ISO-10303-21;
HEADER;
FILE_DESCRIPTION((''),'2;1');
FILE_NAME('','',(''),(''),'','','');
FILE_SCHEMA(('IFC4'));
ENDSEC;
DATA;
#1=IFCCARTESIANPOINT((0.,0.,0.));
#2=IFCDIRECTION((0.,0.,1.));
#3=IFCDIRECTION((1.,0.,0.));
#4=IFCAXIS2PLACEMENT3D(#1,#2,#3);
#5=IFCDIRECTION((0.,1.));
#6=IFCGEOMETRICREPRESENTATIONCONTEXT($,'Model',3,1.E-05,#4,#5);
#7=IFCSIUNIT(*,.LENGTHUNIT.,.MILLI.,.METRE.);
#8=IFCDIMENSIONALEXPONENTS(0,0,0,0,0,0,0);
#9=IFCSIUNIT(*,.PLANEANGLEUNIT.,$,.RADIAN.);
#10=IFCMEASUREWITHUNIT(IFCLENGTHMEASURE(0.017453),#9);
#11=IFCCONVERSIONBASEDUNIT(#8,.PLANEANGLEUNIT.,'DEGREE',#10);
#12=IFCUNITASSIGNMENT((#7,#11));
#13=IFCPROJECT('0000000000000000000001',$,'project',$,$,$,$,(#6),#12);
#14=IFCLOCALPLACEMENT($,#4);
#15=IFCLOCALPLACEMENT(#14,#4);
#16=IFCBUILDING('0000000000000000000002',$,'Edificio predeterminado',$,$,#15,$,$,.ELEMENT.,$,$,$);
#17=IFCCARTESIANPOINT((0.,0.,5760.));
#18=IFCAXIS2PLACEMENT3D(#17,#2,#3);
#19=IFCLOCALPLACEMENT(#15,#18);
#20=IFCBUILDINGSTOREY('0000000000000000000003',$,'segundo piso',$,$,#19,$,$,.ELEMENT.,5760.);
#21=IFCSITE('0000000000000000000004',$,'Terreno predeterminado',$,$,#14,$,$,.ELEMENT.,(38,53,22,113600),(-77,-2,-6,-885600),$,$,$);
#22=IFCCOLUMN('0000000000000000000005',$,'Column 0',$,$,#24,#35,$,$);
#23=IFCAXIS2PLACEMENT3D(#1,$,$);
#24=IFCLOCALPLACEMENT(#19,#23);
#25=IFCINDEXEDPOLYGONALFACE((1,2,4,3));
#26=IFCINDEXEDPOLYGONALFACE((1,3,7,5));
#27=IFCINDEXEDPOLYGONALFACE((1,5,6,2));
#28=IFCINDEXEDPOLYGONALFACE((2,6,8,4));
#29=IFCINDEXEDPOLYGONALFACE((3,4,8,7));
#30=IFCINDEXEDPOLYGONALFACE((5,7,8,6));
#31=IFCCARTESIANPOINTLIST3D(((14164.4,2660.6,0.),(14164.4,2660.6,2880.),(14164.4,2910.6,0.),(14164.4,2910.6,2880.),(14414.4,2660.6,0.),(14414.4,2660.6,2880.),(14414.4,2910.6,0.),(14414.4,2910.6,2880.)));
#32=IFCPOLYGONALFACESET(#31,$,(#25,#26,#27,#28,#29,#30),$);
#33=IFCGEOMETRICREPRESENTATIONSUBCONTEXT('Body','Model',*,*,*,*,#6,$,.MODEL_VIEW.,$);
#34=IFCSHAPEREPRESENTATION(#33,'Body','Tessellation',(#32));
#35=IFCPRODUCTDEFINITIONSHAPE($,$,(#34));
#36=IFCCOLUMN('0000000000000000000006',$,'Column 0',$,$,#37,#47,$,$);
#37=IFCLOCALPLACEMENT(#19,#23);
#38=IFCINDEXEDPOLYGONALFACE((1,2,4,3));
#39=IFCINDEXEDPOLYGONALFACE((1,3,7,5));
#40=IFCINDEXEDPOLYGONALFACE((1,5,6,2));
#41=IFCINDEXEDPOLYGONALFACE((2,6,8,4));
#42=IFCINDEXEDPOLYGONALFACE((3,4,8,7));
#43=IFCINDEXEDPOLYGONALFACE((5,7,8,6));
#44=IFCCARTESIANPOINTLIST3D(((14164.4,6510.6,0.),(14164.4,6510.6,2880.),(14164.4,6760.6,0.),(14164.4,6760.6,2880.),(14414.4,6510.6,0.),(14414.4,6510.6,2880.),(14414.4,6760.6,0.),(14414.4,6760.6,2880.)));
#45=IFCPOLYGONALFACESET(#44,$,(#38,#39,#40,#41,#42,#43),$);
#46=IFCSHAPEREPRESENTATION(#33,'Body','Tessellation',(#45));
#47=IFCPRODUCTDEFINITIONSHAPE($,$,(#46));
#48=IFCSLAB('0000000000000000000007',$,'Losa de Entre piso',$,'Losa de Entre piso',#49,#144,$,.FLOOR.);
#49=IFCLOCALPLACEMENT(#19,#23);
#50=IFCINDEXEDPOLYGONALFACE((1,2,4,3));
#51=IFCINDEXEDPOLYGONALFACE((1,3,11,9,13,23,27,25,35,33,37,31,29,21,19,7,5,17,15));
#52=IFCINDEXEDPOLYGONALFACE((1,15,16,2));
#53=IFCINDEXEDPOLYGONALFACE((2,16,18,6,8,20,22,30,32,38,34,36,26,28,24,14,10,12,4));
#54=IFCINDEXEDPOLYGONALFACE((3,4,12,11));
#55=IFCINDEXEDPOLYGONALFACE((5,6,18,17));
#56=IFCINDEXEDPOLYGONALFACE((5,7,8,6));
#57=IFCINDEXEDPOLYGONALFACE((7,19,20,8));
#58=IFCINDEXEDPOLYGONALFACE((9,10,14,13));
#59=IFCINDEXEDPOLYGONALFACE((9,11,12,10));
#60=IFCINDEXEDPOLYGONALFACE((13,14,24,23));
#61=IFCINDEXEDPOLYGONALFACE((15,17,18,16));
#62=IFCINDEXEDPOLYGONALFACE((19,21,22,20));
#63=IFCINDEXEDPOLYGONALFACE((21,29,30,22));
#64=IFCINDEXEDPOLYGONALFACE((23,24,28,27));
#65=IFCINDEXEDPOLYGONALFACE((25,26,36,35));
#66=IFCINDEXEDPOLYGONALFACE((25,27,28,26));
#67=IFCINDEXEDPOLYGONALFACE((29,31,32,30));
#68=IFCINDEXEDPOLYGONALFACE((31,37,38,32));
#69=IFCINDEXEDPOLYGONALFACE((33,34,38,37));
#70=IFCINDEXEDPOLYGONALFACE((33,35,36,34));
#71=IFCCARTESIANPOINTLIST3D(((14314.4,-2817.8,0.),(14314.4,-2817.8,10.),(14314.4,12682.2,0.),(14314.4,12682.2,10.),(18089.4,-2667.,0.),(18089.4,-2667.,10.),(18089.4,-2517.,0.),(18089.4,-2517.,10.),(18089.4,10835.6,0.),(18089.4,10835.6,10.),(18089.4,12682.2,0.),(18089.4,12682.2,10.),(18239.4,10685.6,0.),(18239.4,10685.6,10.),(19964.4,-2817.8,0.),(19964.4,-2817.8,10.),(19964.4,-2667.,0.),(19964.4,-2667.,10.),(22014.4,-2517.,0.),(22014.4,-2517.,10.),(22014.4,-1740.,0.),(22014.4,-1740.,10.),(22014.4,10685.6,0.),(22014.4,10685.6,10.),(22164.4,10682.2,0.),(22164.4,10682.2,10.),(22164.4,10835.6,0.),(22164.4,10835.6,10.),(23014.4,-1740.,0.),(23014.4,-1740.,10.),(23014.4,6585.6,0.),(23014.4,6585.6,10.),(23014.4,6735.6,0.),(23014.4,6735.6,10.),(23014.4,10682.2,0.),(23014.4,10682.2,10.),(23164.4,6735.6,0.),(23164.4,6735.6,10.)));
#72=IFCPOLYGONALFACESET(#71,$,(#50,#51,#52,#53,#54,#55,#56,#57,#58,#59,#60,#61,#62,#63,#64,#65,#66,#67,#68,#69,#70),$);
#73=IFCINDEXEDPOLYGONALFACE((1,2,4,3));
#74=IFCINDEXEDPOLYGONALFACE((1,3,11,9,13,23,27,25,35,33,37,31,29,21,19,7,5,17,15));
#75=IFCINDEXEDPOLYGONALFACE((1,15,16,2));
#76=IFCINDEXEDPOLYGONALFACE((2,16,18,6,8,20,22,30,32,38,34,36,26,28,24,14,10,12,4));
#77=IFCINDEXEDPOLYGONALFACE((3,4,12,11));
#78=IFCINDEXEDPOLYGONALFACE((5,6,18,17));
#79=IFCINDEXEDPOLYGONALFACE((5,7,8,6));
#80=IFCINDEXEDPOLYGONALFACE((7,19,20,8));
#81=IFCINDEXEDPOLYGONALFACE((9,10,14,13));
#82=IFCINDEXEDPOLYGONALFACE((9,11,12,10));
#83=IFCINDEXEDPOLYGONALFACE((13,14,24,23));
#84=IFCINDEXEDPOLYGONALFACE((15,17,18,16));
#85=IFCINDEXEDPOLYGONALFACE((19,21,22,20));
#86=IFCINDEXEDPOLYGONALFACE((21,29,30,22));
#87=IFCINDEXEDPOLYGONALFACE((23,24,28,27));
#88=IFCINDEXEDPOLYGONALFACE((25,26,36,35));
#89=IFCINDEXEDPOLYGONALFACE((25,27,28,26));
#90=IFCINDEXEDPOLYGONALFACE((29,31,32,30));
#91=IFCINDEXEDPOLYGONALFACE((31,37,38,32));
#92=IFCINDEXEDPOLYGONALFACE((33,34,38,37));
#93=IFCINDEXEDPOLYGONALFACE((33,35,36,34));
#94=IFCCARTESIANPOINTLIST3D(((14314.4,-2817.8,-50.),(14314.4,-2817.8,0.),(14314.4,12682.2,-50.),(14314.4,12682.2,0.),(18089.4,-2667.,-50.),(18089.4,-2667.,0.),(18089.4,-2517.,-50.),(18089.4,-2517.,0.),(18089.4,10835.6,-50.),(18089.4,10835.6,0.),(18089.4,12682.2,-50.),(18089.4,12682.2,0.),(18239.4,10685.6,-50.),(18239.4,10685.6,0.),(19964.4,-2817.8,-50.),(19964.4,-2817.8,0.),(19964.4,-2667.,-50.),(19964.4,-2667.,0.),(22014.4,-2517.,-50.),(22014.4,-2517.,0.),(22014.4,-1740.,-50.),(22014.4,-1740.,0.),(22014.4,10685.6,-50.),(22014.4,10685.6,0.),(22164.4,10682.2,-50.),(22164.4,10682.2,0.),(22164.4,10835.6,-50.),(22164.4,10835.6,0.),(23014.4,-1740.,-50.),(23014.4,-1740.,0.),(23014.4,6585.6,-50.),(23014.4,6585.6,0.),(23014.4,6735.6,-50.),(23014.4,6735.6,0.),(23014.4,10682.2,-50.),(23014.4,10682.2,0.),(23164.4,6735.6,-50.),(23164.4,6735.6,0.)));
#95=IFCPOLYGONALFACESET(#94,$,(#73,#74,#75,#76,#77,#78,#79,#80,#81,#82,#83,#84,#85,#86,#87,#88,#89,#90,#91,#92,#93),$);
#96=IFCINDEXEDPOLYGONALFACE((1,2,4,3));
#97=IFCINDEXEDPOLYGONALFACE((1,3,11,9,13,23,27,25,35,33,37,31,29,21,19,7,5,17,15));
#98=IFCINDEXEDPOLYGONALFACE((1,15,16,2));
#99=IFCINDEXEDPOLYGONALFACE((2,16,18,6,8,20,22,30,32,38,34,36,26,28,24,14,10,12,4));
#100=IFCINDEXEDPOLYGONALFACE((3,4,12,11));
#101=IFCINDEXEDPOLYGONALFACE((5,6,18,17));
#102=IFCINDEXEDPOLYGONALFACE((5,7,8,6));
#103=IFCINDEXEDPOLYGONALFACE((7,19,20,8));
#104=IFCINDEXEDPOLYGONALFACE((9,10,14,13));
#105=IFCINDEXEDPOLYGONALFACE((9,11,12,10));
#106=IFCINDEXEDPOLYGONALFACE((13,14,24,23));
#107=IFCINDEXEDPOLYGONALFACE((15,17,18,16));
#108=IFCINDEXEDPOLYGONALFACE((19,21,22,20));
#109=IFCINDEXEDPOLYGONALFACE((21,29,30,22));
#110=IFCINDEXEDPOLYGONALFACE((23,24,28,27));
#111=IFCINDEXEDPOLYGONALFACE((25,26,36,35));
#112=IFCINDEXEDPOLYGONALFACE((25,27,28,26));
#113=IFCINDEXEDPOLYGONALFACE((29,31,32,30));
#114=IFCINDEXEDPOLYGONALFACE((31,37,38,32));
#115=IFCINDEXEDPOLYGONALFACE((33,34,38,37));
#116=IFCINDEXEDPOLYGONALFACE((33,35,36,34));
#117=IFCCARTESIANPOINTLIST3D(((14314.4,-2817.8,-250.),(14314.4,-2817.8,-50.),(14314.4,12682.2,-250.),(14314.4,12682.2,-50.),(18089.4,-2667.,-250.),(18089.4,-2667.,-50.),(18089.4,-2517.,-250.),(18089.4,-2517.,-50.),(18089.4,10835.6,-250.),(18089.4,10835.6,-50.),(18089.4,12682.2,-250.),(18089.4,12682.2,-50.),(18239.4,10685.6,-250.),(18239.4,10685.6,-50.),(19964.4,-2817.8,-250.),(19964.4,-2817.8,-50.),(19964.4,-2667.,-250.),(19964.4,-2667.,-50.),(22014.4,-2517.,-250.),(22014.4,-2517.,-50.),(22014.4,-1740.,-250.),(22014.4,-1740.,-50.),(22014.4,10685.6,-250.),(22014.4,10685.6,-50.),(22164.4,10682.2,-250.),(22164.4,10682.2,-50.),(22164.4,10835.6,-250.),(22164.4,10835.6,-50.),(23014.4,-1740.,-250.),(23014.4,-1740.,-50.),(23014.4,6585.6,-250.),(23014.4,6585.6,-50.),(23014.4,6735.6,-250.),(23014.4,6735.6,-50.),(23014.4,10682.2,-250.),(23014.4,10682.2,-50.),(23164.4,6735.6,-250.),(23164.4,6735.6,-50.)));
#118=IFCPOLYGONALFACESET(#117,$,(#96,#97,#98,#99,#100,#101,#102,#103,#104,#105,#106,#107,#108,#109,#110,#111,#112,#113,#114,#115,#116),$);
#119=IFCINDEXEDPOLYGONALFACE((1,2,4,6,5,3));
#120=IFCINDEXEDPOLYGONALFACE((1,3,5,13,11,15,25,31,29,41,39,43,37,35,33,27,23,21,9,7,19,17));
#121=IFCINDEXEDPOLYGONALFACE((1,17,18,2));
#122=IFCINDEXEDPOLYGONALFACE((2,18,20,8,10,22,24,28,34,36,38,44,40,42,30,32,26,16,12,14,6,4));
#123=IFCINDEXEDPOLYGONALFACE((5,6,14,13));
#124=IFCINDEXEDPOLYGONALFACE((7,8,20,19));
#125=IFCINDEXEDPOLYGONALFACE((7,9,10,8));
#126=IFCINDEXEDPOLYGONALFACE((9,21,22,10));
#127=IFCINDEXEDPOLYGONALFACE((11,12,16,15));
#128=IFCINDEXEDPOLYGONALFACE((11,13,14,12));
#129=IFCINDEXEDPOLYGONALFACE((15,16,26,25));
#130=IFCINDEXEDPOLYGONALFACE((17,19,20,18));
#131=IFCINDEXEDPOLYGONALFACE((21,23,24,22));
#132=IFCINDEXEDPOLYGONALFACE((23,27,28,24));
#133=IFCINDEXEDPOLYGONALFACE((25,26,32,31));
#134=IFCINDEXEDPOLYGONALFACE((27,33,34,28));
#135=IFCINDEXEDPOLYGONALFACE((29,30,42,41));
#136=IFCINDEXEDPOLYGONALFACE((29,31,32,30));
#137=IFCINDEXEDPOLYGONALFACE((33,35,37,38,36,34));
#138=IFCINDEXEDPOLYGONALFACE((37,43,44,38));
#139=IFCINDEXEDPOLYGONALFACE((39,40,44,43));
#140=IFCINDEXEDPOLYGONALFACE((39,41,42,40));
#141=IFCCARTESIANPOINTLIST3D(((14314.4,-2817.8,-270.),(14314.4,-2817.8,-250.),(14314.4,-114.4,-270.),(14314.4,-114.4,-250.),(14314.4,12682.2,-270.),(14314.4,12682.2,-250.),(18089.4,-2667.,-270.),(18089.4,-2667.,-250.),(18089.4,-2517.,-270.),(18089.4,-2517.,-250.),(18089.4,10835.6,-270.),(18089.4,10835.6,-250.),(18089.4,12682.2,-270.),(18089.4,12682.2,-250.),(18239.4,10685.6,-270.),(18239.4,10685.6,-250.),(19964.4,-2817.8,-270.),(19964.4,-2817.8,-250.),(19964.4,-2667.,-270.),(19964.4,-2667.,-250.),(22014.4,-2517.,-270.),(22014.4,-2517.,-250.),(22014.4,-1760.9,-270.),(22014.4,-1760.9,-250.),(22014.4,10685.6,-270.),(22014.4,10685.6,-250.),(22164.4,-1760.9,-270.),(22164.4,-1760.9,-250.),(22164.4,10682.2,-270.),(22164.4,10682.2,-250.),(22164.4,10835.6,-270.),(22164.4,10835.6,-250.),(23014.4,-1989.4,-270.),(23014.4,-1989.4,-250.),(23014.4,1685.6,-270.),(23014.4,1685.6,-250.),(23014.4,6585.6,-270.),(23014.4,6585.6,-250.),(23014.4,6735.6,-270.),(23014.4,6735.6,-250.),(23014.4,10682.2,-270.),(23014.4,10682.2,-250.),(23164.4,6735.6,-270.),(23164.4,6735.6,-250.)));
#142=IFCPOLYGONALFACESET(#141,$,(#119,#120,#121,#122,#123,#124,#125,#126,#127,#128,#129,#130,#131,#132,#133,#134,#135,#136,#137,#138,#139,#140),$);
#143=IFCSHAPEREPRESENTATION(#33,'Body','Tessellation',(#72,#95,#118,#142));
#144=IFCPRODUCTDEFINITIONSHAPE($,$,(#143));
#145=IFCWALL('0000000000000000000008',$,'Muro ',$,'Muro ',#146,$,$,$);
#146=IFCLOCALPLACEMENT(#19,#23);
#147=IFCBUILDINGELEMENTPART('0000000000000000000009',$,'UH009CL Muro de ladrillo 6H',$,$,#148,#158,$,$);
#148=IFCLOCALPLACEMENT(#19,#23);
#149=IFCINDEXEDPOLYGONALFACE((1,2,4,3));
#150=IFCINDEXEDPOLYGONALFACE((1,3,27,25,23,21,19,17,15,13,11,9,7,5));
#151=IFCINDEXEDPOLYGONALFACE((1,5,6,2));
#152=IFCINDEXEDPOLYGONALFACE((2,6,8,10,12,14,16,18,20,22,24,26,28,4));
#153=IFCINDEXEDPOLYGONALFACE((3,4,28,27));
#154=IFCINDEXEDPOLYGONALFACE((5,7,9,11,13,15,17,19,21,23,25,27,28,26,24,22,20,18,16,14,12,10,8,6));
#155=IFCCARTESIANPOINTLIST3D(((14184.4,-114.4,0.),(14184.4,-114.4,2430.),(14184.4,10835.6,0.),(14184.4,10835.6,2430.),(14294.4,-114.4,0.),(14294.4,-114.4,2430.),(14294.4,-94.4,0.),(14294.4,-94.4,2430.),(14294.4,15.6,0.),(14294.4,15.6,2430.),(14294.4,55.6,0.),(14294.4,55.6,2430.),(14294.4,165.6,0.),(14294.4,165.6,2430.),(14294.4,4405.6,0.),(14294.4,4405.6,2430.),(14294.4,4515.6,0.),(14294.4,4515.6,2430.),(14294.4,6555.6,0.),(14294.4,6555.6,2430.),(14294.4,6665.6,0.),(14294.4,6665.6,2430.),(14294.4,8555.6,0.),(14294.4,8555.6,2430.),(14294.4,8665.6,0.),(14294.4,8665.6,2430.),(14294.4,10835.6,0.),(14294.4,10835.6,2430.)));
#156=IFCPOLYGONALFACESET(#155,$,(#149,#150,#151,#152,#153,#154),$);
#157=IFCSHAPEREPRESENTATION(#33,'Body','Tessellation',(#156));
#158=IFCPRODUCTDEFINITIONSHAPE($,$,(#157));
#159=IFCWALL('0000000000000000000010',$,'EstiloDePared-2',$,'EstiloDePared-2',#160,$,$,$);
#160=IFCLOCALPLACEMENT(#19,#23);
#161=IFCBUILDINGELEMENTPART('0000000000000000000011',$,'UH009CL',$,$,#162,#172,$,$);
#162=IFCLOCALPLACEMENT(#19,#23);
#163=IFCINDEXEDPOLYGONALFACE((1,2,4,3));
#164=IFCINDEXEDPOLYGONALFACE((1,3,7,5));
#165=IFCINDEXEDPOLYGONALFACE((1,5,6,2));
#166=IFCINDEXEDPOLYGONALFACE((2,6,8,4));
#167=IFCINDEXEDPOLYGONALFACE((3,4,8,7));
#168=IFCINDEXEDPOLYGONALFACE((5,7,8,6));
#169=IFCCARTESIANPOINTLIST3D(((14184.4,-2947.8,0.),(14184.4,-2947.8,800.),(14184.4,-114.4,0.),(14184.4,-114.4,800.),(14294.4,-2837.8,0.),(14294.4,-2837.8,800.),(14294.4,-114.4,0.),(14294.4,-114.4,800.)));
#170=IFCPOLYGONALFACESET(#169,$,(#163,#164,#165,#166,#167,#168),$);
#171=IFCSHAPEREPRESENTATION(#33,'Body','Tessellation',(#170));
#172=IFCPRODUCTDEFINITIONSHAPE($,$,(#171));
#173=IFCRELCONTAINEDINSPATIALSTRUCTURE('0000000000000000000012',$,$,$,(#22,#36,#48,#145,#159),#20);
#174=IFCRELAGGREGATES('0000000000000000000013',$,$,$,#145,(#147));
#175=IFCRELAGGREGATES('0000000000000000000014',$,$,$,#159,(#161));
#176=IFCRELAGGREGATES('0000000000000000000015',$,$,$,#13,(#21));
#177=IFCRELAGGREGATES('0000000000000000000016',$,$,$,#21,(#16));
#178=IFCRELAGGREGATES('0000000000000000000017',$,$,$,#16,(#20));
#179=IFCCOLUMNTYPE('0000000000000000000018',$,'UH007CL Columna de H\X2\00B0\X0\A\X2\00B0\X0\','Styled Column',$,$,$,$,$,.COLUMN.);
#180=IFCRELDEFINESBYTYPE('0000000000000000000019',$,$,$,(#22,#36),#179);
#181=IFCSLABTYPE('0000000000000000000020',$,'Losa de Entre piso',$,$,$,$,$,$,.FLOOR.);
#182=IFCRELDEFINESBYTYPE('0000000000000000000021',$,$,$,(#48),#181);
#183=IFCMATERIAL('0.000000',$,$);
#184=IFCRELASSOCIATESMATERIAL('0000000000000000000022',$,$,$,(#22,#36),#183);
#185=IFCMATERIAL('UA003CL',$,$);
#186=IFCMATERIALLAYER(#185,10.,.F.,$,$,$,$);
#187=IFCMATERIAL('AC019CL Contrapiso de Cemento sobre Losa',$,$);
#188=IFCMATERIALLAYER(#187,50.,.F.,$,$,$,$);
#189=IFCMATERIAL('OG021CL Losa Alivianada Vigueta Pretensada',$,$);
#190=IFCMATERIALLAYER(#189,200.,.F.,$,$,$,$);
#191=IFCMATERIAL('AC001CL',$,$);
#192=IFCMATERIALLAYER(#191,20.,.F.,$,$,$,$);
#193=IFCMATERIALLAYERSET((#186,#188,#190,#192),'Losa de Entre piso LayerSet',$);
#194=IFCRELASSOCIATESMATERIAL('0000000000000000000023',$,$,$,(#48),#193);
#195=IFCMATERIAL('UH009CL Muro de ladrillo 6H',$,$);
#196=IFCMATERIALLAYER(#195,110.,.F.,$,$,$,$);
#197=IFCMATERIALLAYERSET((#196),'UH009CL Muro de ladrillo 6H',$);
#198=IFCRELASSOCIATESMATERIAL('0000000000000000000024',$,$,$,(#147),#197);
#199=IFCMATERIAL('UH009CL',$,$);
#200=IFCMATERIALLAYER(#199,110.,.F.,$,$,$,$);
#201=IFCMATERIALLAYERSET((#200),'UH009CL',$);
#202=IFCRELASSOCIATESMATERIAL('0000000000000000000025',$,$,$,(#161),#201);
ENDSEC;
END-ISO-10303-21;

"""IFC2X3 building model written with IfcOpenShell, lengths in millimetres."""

from ifc_helpers import new_model, entity, si_unit, converted_unit, direction, frame, origin_with_axes, place, context, subcontext, project, spatial, polyline, outline, extrude, material, layer, layer_set, layer_usage, type_object, element, aggregate, save


model = new_model("IFC2X3")

# Units and contexts
model_context = context("Model", 3, precision=1e-05, world=origin_with_axes(), true_north=direction((0.0, 1.0)))
body_context = subcontext(model_context, "Body", "Model", "MODEL_VIEW")
ifc_project = project(units=[si_unit("LENGTHUNIT", "METRE", prefix="MILLI"), converted_unit("PLANEANGLEUNIT", "DEGREE", entity("IfcLengthMeasure", 0.017453), si_unit("PLANEANGLEUNIT", "RADIAN"), dimensions=[0, 0, 0, 0, 0, 0, 0])], contexts=[model_context])

# Site, building, storey
site_placement = place(None, origin_with_axes())
site = spatial("IfcSite", under=ifc_project, at=site_placement, Name="Terreno predeterminado", CompositionType="ELEMENT", RefLatitude=(38, 53, 22, 113600), RefLongitude=(-77, -2, -6, -885600))
building_placement = place(site_placement, origin_with_axes())
building = spatial("IfcBuilding", under=site, at=building_placement, Name="Edificio predeterminado", CompositionType="ELEMENT")
storey_placement = place(building_placement, frame((0.0, 0.0, 5760.0), z_axis=(0.0, 0.0, 1.0), x_axis=(1.0, 0.0, 0.0)))
storey = spatial("IfcBuildingStorey", under=building, at=storey_placement, Name="segundo piso", CompositionType="ELEMENT", Elevation=5760.0)

# Columns
ifc_material_1 = material(Name="0.000000")
column_type = type_object("IfcColumnType", Name="UH007CL Columna de H°A°", Description="Styled Column", PredefinedType="COLUMN")
for number, where, z_axis, x_axis, name in (
    (1, (14289.4, 2785.6, 0.0), (0.0, 0.0, 1.0), (1.0, 0.0, 0.0), "Column 0"),
    (2, (14289.4, 6635.6, 0.0), (0.0, 0.0, 1.0), (1.0, 0.0, 0.0), "Column 0"),
):
    element("IfcColumn", number, at=place(storey_placement, frame(where, z_axis=z_axis, x_axis=x_axis)), inside=storey, type_object=column_type, material=ifc_material_1, Name=name, context=body_context, shape_type="SweptSolid", body=[
        extrude(outline(polyline([(-125.0, -125.0), (125.0, -125.0), (125.0, 125.0), (-125.0, 125.0), (-125.0, -125.0)])), origin_with_axes(), (0.0, 0.0, 1.0), 2880.0),
    ])

# Slab
ifc_material_2 = material(Name="UA003CL")
ifc_layer_1 = layer(ifc_material_2, 10.0, ventilated=False)
ifc_material_3 = material(Name="AC019CL Contrapiso de Cemento sobre Losa")
ifc_layer_2 = layer(ifc_material_3, 50.0, ventilated=False)
ifc_material_4 = material(Name="OG021CL Losa Alivianada Vigueta Pretensada")
ifc_layer_3 = layer(ifc_material_4, 200.0, ventilated=False)
ifc_material_5 = material(Name="AC001CL")
ifc_layer_4 = layer(ifc_material_5, 20.0, ventilated=False)
ifc_layer_set_1 = layer_set([ifc_layer_1, ifc_layer_2, ifc_layer_3, ifc_layer_4], Name="Losa de Entre piso LayerSet")
ifc_layer_usage_1 = layer_usage(ifc_layer_set_1, "AXIS3", "POSITIVE", 0.0)
slab_type = type_object("IfcSlabType", Name="Losa de Entre piso", PredefinedType="FLOOR")
slab_placement = place(storey_placement, frame((0.0, 0.0, -5760.0), z_axis=(0.0, 0.0, 1.0), x_axis=(1.0, 0.0, 0.0)))
element("IfcSlab", 3, at=slab_placement, inside=storey, type_object=slab_type, material=ifc_layer_usage_1, Name="Losa de Entre piso", ObjectType="Losa de Entre piso", PredefinedType="FLOOR", context=body_context, shape_type="SweptSolid", body=[
    extrude(outline(polyline([(0.0, -777.0), (-1000.0, -777.0), (-1000.0, -9102.6), (-1150.0, -9252.6), (-1000.0, -9252.6), (-1000.0, -13199.1), (-150.0, -13199.1), (-150.0, -13352.6), (0.0, -13202.6), (3775.0, -13202.6), (3925.0, -13352.6), (3925.0, -15199.1), (7700.0, -15199.1), (7700.0, 300.9), (2050.0, 300.9), (2050.0, 150.0), (3925.0, 150.0), (3925.0, 0.0), (0.0, 0.0), (0.0, -777.0)])), frame((22014.4, -2517.0, 5760.0), z_axis=(0.0, 0.0, 1.0), x_axis=(-1.0, 0.0, 0.0)), (0.0, 0.0, 1.0), 10.0),
    extrude(outline(polyline([(0.0, -777.0), (-1000.0, -777.0), (-1000.0, -9102.6), (-1150.0, -9252.6), (-1000.0, -9252.6), (-1000.0, -13199.1), (-150.0, -13199.1), (-150.0, -13352.6), (0.0, -13202.6), (3775.0, -13202.6), (3925.0, -13352.6), (3925.0, -15199.1), (7700.0, -15199.1), (7700.0, 300.9), (2050.0, 300.9), (2050.0, 150.0), (3925.0, 150.0), (3925.0, 0.0), (0.0, 0.0), (0.0, -777.0)])), frame((22014.4, -2517.0, 5710.0), z_axis=(0.0, 0.0, 1.0), x_axis=(-1.0, 0.0, 0.0)), (0.0, 0.0, 1.0), 50.0),
    extrude(outline(polyline([(0.0, -777.0), (-1000.0, -777.0), (-1000.0, -9102.6), (-1150.0, -9252.6), (-1000.0, -9252.6), (-1000.0, -13199.1), (-150.0, -13199.1), (-150.0, -13352.6), (0.0, -13202.6), (3775.0, -13202.6), (3925.0, -13352.6), (3925.0, -15199.1), (7700.0, -15199.1), (7700.0, 300.9), (2050.0, 300.9), (2050.0, 150.0), (3925.0, 150.0), (3925.0, 0.0), (0.0, 0.0), (0.0, -777.0)])), frame((22014.4, -2517.0, 5510.0), z_axis=(0.0, 0.0, 1.0), x_axis=(-1.0, 0.0, 0.0)), (0.0, 0.0, 1.0), 200.0),
    extrude(outline(polyline([(-1305.7, 1305.7), (-3975.1, -1363.6), (5073.5, -10412.1), (6985.1, -12323.8), (10980.3, -8328.6), (10873.6, -8221.9), (9547.8, -9547.8), (9441.7, -9441.7), (12217.1, -6666.3), (11682.5, -6131.7), (11788.6, -6025.7), (12551.1, -5586.1), (9952.5, -2987.5), (6487.7, 477.3), (6487.7, 689.4), (6381.6, 583.4), (3591.0, 3374.0), (2990.0, 2773.0), (2881.5, 2881.5), (2881.5, 2669.3), (212.1, 0.0), (0.0, 0.0), (-1305.7, 1305.7)])), frame((18089.4, 10835.6, 5490.0), z_axis=(0.0, 0.0, 1.0), x_axis=(0.707107, -0.707107, 0.0)), (0.0, 0.0, 1.0), 20.0),
])

# Walls, building element parts
wall_1_placement = place(storey_placement, frame((14239.4, 10835.6, 0.0), z_axis=(0.0, 0.0, 1.0), x_axis=(0.0, -1.0, 0.0)))
wall_1 = element("IfcWall", 4, at=wall_1_placement, inside=storey, Name="Muro ", ObjectType="Muro ")
ifc_material_6 = material(Name="UH009CL Muro de ladrillo 6H")
ifc_layer_5 = layer(ifc_material_6, 110.0, ventilated=False)
ifc_layer_set_2 = layer_set([ifc_layer_5], Name="UH009CL Muro de ladrillo 6H")
ifc_layer_usage_2 = layer_usage(ifc_layer_set_2, "AXIS2", "NEGATIVE", -55.0)
building_element_part_1_placement = place(wall_1_placement, origin_with_axes())
building_element_part_1 = element("IfcBuildingElementPart", 5, at=building_element_part_1_placement, material=ifc_layer_usage_2, Name="UH009CL Muro de ladrillo 6H", context=body_context, shape_type="SweptSolid", body=[
    extrude(outline(polyline([(4280.0, 55.0), (6320.0, 55.0), (6430.0, 55.0), (10670.0, 55.0), (10780.0, 55.0), (10820.0, 55.0), (10930.0, 55.0), (10950.0, 55.0), (10950.0, -55.0), (0.0, -55.0), (0.0, 55.0), (2170.0, 55.0), (2280.0, 55.0), (4170.0, 55.0), (4280.0, 55.0)])), origin_with_axes(), (0.0, 0.0, 1.0), 2430.0),
])
aggregate(wall_1, [building_element_part_1])
wall_2_placement = place(storey_placement, frame((14239.4, -2892.8, 0.0), z_axis=(0.0, 0.0, 1.0), x_axis=(0.0, 1.0, 0.0)))
wall_2 = element("IfcWall", 6, at=wall_2_placement, inside=storey, Name="EstiloDePared-2", ObjectType="EstiloDePared-2")
ifc_material_7 = material(Name="UH009CL")
ifc_layer_6 = layer(ifc_material_7, 110.0, ventilated=False)
ifc_layer_set_3 = layer_set([ifc_layer_6], Name="UH009CL")
ifc_layer_usage_3 = layer_usage(ifc_layer_set_3, "AXIS2", "NEGATIVE", -55.0)
building_element_part_2_placement = place(wall_2_placement, origin_with_axes())
building_element_part_2 = element("IfcBuildingElementPart", 7, at=building_element_part_2_placement, material=ifc_layer_usage_3, Name="UH009CL", context=body_context, shape_type="SweptSolid", body=[
    extrude(outline(polyline([(2778.4, 55.0), (2778.4, -55.0), (55.0, -55.0), (-55.0, 55.0), (2778.4, 55.0)])), origin_with_axes(), (0.0, 0.0, 1.0), 800.0),
])
aggregate(wall_2, [building_element_part_2])

save(model, "model.ifc")
